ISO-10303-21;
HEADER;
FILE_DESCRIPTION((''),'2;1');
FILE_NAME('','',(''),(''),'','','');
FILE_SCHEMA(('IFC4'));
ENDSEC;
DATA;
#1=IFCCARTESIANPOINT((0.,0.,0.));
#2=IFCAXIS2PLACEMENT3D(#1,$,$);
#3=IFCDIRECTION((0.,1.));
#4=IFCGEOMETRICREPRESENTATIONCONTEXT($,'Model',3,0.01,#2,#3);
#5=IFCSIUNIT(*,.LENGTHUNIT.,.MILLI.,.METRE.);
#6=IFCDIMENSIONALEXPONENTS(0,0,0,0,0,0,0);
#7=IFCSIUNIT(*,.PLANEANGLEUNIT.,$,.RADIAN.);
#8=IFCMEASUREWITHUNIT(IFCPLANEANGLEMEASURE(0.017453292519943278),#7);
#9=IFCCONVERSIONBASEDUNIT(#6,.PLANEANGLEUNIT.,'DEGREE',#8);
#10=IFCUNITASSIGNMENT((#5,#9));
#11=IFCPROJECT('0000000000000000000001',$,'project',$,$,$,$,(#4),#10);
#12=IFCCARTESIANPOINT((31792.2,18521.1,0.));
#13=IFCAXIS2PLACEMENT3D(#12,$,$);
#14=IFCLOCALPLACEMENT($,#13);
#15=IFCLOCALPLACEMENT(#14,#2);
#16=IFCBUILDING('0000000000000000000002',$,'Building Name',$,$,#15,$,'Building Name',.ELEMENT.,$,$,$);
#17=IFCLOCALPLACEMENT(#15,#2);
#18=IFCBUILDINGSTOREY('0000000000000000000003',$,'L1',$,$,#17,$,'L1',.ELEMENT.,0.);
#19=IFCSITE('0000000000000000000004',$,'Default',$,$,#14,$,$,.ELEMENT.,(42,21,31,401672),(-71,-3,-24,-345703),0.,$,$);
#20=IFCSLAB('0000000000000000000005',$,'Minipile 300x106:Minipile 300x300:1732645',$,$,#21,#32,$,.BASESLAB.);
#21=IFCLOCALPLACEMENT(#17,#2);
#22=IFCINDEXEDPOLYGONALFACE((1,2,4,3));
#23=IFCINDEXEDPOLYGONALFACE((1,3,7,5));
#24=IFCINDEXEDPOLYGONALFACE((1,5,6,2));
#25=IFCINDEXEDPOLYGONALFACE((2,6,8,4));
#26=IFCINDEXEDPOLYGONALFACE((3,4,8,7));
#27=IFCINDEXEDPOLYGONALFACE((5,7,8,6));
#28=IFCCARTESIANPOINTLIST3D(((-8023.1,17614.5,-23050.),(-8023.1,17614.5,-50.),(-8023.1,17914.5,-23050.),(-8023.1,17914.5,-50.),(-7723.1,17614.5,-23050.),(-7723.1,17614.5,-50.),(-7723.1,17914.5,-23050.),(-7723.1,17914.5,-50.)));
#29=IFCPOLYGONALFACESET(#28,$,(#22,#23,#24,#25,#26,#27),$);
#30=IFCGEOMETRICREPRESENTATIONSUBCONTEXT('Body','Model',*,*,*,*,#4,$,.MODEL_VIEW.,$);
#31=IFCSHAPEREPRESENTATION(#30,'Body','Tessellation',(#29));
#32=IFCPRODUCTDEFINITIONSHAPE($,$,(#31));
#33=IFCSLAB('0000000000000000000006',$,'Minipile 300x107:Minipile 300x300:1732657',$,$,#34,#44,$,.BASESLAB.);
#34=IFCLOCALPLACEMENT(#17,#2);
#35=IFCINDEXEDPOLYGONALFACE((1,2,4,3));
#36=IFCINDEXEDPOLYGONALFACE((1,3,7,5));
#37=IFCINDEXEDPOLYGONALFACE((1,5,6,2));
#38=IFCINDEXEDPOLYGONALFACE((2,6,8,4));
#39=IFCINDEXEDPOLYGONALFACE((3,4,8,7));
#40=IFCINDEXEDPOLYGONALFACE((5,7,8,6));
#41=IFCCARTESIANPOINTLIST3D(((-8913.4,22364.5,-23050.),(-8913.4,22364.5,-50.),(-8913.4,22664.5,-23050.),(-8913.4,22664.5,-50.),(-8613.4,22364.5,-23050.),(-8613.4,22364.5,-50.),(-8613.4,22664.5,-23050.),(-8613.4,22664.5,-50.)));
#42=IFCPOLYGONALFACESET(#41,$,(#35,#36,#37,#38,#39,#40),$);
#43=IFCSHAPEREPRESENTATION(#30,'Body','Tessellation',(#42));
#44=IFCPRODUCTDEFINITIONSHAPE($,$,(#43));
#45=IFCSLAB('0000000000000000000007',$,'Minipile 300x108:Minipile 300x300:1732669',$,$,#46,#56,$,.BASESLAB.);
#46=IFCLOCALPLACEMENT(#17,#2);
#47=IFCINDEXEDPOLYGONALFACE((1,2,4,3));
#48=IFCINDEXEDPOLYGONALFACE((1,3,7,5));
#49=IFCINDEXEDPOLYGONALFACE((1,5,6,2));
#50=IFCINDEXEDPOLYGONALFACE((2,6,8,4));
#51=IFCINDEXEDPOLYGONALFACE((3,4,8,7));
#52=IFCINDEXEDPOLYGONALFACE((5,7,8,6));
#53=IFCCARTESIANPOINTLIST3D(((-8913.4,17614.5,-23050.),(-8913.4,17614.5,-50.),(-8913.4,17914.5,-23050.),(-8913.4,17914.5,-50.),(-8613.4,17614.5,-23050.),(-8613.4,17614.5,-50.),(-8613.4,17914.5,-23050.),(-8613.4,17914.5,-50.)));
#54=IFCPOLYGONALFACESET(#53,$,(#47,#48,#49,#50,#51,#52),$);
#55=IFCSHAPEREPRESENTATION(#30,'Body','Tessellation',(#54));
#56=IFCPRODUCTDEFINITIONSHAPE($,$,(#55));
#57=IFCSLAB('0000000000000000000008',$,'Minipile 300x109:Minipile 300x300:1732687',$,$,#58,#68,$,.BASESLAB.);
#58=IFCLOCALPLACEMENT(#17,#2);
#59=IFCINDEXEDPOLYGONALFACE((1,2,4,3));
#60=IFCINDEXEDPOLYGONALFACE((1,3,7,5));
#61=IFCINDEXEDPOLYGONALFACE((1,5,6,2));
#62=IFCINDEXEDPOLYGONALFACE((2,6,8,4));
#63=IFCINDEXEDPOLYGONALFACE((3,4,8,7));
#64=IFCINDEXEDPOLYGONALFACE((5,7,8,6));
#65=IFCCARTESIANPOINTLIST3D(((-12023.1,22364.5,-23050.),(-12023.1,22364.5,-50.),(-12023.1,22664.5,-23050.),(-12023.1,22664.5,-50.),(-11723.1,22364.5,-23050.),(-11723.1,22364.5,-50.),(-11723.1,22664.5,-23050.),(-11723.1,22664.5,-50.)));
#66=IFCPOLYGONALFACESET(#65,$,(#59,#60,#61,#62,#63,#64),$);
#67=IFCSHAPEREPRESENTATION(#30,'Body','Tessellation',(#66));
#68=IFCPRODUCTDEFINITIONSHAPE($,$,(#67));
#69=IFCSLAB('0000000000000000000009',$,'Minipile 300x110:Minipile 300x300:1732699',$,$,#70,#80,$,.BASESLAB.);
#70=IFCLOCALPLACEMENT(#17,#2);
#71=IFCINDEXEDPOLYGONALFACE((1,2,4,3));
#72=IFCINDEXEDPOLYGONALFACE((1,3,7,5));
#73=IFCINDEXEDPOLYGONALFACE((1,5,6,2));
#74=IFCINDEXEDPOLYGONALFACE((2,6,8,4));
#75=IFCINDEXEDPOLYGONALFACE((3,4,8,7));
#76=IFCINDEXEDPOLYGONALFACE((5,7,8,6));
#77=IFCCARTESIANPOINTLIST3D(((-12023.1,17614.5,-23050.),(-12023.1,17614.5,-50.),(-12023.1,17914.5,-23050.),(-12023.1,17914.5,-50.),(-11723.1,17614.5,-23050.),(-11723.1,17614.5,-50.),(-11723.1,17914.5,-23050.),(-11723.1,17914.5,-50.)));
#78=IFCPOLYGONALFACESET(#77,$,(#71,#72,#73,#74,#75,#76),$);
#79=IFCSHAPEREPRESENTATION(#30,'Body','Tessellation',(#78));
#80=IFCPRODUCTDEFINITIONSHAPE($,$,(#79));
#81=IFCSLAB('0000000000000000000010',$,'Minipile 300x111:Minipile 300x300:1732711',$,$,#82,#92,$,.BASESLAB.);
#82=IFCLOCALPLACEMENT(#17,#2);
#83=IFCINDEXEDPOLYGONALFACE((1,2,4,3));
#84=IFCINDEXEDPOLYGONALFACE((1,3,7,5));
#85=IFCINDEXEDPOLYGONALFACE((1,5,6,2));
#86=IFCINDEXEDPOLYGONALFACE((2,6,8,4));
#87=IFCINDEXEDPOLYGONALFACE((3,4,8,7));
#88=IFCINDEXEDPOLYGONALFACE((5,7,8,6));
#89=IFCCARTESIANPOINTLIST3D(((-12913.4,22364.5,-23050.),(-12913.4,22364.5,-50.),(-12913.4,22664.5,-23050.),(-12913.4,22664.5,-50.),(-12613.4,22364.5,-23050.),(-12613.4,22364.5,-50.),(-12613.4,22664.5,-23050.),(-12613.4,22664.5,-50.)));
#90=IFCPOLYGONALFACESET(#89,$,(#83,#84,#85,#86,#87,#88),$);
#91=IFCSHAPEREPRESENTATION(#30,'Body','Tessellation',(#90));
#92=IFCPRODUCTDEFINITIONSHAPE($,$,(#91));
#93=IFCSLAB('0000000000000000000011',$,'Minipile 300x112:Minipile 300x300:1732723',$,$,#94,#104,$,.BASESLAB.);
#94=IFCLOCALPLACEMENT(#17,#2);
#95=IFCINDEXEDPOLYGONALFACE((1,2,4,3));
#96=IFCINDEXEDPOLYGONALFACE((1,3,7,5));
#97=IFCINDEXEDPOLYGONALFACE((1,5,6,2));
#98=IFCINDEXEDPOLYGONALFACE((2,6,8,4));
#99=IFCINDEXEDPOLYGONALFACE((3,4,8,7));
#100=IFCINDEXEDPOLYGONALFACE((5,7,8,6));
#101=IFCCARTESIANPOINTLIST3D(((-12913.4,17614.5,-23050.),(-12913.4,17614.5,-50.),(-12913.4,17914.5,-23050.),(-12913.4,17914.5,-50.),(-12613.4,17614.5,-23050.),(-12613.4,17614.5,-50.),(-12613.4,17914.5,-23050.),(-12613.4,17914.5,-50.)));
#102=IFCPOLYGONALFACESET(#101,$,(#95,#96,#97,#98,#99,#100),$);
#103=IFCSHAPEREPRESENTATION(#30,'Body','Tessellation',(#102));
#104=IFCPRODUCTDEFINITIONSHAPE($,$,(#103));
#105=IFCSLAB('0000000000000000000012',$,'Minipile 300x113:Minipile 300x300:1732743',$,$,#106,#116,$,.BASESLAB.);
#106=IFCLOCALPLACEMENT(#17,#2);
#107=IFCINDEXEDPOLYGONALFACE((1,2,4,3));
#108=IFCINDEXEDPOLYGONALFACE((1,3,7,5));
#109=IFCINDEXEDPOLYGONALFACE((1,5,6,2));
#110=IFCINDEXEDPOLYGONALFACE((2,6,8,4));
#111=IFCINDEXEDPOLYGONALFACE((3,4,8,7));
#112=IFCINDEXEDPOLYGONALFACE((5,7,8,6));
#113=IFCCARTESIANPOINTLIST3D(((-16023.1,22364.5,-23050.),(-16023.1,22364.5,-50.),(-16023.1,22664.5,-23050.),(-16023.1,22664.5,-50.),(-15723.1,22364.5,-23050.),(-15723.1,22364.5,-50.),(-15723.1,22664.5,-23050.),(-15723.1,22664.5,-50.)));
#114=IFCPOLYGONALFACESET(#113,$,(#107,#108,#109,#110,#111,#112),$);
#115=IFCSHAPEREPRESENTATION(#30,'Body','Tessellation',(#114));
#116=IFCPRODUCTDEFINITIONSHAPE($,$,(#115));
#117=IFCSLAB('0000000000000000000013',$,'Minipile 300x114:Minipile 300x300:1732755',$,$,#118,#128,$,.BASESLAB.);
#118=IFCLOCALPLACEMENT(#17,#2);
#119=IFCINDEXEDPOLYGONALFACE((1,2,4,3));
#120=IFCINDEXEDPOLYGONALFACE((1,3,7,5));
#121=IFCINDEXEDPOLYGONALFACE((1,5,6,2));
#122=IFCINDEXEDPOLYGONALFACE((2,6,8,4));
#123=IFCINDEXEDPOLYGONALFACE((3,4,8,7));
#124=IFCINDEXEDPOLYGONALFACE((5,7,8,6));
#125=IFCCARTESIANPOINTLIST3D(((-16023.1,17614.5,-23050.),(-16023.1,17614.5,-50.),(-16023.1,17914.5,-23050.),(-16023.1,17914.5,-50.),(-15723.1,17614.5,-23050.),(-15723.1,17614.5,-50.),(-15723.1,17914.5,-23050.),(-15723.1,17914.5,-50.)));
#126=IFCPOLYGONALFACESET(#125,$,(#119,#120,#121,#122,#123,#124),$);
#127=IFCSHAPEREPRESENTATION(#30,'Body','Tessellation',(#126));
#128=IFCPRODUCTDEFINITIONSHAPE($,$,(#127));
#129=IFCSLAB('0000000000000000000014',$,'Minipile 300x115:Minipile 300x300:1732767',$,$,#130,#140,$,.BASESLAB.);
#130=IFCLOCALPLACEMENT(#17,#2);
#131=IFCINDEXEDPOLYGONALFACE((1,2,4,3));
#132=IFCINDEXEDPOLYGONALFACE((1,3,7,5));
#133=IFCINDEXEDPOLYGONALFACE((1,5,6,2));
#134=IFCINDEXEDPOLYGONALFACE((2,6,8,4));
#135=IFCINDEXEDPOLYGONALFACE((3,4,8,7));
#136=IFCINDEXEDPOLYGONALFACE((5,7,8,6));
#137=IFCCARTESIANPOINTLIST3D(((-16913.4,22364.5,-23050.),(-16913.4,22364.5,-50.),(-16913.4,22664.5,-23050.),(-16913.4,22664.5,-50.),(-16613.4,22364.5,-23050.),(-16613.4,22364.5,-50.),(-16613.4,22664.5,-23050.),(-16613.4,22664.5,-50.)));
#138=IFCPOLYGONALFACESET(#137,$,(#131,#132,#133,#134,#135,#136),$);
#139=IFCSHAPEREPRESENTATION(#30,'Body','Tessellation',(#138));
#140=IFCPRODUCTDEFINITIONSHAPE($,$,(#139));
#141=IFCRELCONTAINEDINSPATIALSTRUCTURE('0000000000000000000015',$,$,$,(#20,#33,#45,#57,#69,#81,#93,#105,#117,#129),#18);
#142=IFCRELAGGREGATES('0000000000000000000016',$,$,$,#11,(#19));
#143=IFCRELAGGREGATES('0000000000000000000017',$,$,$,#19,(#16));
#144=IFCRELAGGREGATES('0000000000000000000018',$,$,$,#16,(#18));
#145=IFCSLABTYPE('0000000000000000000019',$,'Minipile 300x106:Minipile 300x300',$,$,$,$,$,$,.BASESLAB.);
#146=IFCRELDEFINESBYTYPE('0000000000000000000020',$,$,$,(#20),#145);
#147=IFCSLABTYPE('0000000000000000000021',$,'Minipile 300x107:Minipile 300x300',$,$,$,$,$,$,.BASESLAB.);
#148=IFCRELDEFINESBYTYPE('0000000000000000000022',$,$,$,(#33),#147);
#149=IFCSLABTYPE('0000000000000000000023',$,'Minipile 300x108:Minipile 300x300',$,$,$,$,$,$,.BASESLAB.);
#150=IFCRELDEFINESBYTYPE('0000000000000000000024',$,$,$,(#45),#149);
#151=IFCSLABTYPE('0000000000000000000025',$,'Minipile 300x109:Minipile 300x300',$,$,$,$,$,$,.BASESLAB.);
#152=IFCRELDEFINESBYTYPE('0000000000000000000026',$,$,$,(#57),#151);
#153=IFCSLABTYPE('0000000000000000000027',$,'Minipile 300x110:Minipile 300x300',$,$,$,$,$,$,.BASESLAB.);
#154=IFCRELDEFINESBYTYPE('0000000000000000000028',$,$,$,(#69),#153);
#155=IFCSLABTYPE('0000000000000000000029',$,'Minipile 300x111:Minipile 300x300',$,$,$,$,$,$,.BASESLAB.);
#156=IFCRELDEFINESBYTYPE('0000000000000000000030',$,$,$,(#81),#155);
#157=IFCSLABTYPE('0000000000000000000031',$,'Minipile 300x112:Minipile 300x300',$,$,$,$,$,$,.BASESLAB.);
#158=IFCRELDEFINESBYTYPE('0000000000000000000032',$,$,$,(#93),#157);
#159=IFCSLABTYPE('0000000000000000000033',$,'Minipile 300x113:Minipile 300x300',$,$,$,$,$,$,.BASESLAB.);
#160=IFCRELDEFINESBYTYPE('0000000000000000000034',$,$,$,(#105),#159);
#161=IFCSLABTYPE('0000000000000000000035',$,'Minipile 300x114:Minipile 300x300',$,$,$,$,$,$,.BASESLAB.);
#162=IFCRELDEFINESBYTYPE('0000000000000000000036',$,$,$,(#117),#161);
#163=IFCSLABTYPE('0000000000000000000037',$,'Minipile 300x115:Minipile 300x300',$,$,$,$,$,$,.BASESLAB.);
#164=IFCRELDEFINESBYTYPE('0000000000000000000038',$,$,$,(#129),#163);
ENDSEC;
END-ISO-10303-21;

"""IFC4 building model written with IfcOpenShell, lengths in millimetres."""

from ifc_helpers import new_model, entity, si_unit, converted_unit, direction, frame, origin, place, context, subcontext, project, spatial, indexed_curve, outline, extrude, type_object, element, save


model = new_model("IFC4")

# Units and contexts
model_context = context("Model", 3, precision=0.01, world=origin(), true_north=direction((0.0, 1.0)))
body_context = subcontext(model_context, "Body", "Model", "MODEL_VIEW")
ifc_project = project(units=[si_unit("LENGTHUNIT", "METRE", prefix="MILLI"), converted_unit("PLANEANGLEUNIT", "DEGREE", entity("IfcPlaneAngleMeasure", 0.017453292519943278), si_unit("PLANEANGLEUNIT", "RADIAN"), dimensions=[0, 0, 0, 0, 0, 0, 0])], contexts=[model_context])

# Site, building, storey
site_placement = place(None, frame((31792.2, 18521.1, 0.0)))
site = spatial("IfcSite", under=ifc_project, at=site_placement, Name="Default", CompositionType="ELEMENT", RefLatitude=(42, 21, 31, 401672), RefLongitude=(-71, -3, -24, -345703), RefElevation=0.0)
building_placement = place(site_placement, origin())
building = spatial("IfcBuilding", under=site, at=building_placement, Name="Building Name", LongName="Building Name", CompositionType="ELEMENT")
storey_placement = place(building_placement, origin())
storey = spatial("IfcBuildingStorey", under=building, at=storey_placement, Name="L1", LongName="L1", CompositionType="ELEMENT", Elevation=0.0)

# Slabs
slab_type_1 = type_object("IfcSlabType", Name="Minipile 300x106:Minipile 300x300", PredefinedType="BASESLAB")
slab_1_placement = place(storey_placement, origin())
element("IfcSlab", 1, at=slab_1_placement, inside=storey, type_object=slab_type_1, Name="Minipile 300x106:Minipile 300x300:1732645", PredefinedType="BASESLAB", context=body_context, shape_type="SweptSolid", body=[
    extrude(outline(indexed_curve([(-150.0, -150.0), (150.0, -150.0), (150.0, 150.0), (-150.0, 150.0), (-150.0, -150.0)], self_intersect=False)), frame((-7873.1, 17764.5, -23050.0), z_axis=(0.0, 0.0, 1.0), x_axis=(0.0, -1.0, 0.0)), (0.0, 0.0, 1.0), 23000.0),
])
slab_type_2 = type_object("IfcSlabType", Name="Minipile 300x107:Minipile 300x300", PredefinedType="BASESLAB")
slab_2_placement = place(storey_placement, origin())
element("IfcSlab", 2, at=slab_2_placement, inside=storey, type_object=slab_type_2, Name="Minipile 300x107:Minipile 300x300:1732657", PredefinedType="BASESLAB", context=body_context, shape_type="SweptSolid", body=[
    extrude(outline(indexed_curve([(-150.0, -150.0), (150.0, -150.0), (150.0, 150.0), (-150.0, 150.0), (-150.0, -150.0)], self_intersect=False)), frame((-8763.4, 22514.5, -23050.0), z_axis=(0.0, 0.0, 1.0), x_axis=(0.0, -1.0, 0.0)), (0.0, 0.0, 1.0), 23000.0),
])
slab_type_3 = type_object("IfcSlabType", Name="Minipile 300x108:Minipile 300x300", PredefinedType="BASESLAB")
slab_3_placement = place(storey_placement, origin())
element("IfcSlab", 3, at=slab_3_placement, inside=storey, type_object=slab_type_3, Name="Minipile 300x108:Minipile 300x300:1732669", PredefinedType="BASESLAB", context=body_context, shape_type="SweptSolid", body=[
    extrude(outline(indexed_curve([(-150.0, -150.0), (150.0, -150.0), (150.0, 150.0), (-150.0, 150.0), (-150.0, -150.0)], self_intersect=False)), frame((-8763.4, 17764.5, -23050.0), z_axis=(0.0, 0.0, 1.0), x_axis=(0.0, -1.0, 0.0)), (0.0, 0.0, 1.0), 23000.0),
])
slab_type_4 = type_object("IfcSlabType", Name="Minipile 300x109:Minipile 300x300", PredefinedType="BASESLAB")
slab_4_placement = place(storey_placement, origin())
element("IfcSlab", 4, at=slab_4_placement, inside=storey, type_object=slab_type_4, Name="Minipile 300x109:Minipile 300x300:1732687", PredefinedType="BASESLAB", context=body_context, shape_type="SweptSolid", body=[
    extrude(outline(indexed_curve([(-150.0, -150.0), (150.0, -150.0), (150.0, 150.0), (-150.0, 150.0), (-150.0, -150.0)], self_intersect=False)), frame((-11873.1, 22514.5, -23050.0), z_axis=(0.0, 0.0, 1.0), x_axis=(0.0, -1.0, 0.0)), (0.0, 0.0, 1.0), 23000.0),
])
slab_type_5 = type_object("IfcSlabType", Name="Minipile 300x110:Minipile 300x300", PredefinedType="BASESLAB")
slab_5_placement = place(storey_placement, origin())
element("IfcSlab", 5, at=slab_5_placement, inside=storey, type_object=slab_type_5, Name="Minipile 300x110:Minipile 300x300:1732699", PredefinedType="BASESLAB", context=body_context, shape_type="SweptSolid", body=[
    extrude(outline(indexed_curve([(-150.0, -150.0), (150.0, -150.0), (150.0, 150.0), (-150.0, 150.0), (-150.0, -150.0)], self_intersect=False)), frame((-11873.1, 17764.5, -23050.0), z_axis=(0.0, 0.0, 1.0), x_axis=(0.0, -1.0, 0.0)), (0.0, 0.0, 1.0), 23000.0),
])
slab_type_6 = type_object("IfcSlabType", Name="Minipile 300x111:Minipile 300x300", PredefinedType="BASESLAB")
slab_6_placement = place(storey_placement, origin())
element("IfcSlab", 6, at=slab_6_placement, inside=storey, type_object=slab_type_6, Name="Minipile 300x111:Minipile 300x300:1732711", PredefinedType="BASESLAB", context=body_context, shape_type="SweptSolid", body=[
    extrude(outline(indexed_curve([(-150.0, -150.0), (150.0, -150.0), (150.0, 150.0), (-150.0, 150.0), (-150.0, -150.0)], self_intersect=False)), frame((-12763.4, 22514.5, -23050.0), z_axis=(0.0, 0.0, 1.0), x_axis=(0.0, -1.0, 0.0)), (0.0, 0.0, 1.0), 23000.0),
])
slab_type_7 = type_object("IfcSlabType", Name="Minipile 300x112:Minipile 300x300", PredefinedType="BASESLAB")
slab_7_placement = place(storey_placement, origin())
element("IfcSlab", 7, at=slab_7_placement, inside=storey, type_object=slab_type_7, Name="Minipile 300x112:Minipile 300x300:1732723", PredefinedType="BASESLAB", context=body_context, shape_type="SweptSolid", body=[
    extrude(outline(indexed_curve([(-150.0, -150.0), (150.0, -150.0), (150.0, 150.0), (-150.0, 150.0), (-150.0, -150.0)], self_intersect=False)), frame((-12763.4, 17764.5, -23050.0), z_axis=(0.0, 0.0, 1.0), x_axis=(0.0, -1.0, 0.0)), (0.0, 0.0, 1.0), 23000.0),
])
slab_type_8 = type_object("IfcSlabType", Name="Minipile 300x113:Minipile 300x300", PredefinedType="BASESLAB")
slab_8_placement = place(storey_placement, origin())
element("IfcSlab", 8, at=slab_8_placement, inside=storey, type_object=slab_type_8, Name="Minipile 300x113:Minipile 300x300:1732743", PredefinedType="BASESLAB", context=body_context, shape_type="SweptSolid", body=[
    extrude(outline(indexed_curve([(-150.0, -150.0), (150.0, -150.0), (150.0, 150.0), (-150.0, 150.0), (-150.0, -150.0)], self_intersect=False)), frame((-15873.1, 22514.5, -23050.0), z_axis=(0.0, 0.0, 1.0), x_axis=(0.0, -1.0, 0.0)), (0.0, 0.0, 1.0), 23000.0),
])
slab_type_9 = type_object("IfcSlabType", Name="Minipile 300x114:Minipile 300x300", PredefinedType="BASESLAB")
slab_9_placement = place(storey_placement, origin())
element("IfcSlab", 9, at=slab_9_placement, inside=storey, type_object=slab_type_9, Name="Minipile 300x114:Minipile 300x300:1732755", PredefinedType="BASESLAB", context=body_context, shape_type="SweptSolid", body=[
    extrude(outline(indexed_curve([(-150.0, -150.0), (150.0, -150.0), (150.0, 150.0), (-150.0, 150.0), (-150.0, -150.0)], self_intersect=False)), frame((-15873.1, 17764.5, -23050.0), z_axis=(0.0, 0.0, 1.0), x_axis=(0.0, -1.0, 0.0)), (0.0, 0.0, 1.0), 23000.0),
])
slab_type_10 = type_object("IfcSlabType", Name="Minipile 300x115:Minipile 300x300", PredefinedType="BASESLAB")
slab_10_placement = place(storey_placement, origin())
element("IfcSlab", 10, at=slab_10_placement, inside=storey, type_object=slab_type_10, Name="Minipile 300x115:Minipile 300x300:1732767", PredefinedType="BASESLAB", context=body_context, shape_type="SweptSolid", body=[
    extrude(outline(indexed_curve([(-150.0, -150.0), (150.0, -150.0), (150.0, 150.0), (-150.0, 150.0), (-150.0, -150.0)], self_intersect=False)), frame((-16763.4, 22514.5, -23050.0), z_axis=(0.0, 0.0, 1.0), x_axis=(0.0, -1.0, 0.0)), (0.0, 0.0, 1.0), 23000.0),
])

save(model, "model.ifc")
